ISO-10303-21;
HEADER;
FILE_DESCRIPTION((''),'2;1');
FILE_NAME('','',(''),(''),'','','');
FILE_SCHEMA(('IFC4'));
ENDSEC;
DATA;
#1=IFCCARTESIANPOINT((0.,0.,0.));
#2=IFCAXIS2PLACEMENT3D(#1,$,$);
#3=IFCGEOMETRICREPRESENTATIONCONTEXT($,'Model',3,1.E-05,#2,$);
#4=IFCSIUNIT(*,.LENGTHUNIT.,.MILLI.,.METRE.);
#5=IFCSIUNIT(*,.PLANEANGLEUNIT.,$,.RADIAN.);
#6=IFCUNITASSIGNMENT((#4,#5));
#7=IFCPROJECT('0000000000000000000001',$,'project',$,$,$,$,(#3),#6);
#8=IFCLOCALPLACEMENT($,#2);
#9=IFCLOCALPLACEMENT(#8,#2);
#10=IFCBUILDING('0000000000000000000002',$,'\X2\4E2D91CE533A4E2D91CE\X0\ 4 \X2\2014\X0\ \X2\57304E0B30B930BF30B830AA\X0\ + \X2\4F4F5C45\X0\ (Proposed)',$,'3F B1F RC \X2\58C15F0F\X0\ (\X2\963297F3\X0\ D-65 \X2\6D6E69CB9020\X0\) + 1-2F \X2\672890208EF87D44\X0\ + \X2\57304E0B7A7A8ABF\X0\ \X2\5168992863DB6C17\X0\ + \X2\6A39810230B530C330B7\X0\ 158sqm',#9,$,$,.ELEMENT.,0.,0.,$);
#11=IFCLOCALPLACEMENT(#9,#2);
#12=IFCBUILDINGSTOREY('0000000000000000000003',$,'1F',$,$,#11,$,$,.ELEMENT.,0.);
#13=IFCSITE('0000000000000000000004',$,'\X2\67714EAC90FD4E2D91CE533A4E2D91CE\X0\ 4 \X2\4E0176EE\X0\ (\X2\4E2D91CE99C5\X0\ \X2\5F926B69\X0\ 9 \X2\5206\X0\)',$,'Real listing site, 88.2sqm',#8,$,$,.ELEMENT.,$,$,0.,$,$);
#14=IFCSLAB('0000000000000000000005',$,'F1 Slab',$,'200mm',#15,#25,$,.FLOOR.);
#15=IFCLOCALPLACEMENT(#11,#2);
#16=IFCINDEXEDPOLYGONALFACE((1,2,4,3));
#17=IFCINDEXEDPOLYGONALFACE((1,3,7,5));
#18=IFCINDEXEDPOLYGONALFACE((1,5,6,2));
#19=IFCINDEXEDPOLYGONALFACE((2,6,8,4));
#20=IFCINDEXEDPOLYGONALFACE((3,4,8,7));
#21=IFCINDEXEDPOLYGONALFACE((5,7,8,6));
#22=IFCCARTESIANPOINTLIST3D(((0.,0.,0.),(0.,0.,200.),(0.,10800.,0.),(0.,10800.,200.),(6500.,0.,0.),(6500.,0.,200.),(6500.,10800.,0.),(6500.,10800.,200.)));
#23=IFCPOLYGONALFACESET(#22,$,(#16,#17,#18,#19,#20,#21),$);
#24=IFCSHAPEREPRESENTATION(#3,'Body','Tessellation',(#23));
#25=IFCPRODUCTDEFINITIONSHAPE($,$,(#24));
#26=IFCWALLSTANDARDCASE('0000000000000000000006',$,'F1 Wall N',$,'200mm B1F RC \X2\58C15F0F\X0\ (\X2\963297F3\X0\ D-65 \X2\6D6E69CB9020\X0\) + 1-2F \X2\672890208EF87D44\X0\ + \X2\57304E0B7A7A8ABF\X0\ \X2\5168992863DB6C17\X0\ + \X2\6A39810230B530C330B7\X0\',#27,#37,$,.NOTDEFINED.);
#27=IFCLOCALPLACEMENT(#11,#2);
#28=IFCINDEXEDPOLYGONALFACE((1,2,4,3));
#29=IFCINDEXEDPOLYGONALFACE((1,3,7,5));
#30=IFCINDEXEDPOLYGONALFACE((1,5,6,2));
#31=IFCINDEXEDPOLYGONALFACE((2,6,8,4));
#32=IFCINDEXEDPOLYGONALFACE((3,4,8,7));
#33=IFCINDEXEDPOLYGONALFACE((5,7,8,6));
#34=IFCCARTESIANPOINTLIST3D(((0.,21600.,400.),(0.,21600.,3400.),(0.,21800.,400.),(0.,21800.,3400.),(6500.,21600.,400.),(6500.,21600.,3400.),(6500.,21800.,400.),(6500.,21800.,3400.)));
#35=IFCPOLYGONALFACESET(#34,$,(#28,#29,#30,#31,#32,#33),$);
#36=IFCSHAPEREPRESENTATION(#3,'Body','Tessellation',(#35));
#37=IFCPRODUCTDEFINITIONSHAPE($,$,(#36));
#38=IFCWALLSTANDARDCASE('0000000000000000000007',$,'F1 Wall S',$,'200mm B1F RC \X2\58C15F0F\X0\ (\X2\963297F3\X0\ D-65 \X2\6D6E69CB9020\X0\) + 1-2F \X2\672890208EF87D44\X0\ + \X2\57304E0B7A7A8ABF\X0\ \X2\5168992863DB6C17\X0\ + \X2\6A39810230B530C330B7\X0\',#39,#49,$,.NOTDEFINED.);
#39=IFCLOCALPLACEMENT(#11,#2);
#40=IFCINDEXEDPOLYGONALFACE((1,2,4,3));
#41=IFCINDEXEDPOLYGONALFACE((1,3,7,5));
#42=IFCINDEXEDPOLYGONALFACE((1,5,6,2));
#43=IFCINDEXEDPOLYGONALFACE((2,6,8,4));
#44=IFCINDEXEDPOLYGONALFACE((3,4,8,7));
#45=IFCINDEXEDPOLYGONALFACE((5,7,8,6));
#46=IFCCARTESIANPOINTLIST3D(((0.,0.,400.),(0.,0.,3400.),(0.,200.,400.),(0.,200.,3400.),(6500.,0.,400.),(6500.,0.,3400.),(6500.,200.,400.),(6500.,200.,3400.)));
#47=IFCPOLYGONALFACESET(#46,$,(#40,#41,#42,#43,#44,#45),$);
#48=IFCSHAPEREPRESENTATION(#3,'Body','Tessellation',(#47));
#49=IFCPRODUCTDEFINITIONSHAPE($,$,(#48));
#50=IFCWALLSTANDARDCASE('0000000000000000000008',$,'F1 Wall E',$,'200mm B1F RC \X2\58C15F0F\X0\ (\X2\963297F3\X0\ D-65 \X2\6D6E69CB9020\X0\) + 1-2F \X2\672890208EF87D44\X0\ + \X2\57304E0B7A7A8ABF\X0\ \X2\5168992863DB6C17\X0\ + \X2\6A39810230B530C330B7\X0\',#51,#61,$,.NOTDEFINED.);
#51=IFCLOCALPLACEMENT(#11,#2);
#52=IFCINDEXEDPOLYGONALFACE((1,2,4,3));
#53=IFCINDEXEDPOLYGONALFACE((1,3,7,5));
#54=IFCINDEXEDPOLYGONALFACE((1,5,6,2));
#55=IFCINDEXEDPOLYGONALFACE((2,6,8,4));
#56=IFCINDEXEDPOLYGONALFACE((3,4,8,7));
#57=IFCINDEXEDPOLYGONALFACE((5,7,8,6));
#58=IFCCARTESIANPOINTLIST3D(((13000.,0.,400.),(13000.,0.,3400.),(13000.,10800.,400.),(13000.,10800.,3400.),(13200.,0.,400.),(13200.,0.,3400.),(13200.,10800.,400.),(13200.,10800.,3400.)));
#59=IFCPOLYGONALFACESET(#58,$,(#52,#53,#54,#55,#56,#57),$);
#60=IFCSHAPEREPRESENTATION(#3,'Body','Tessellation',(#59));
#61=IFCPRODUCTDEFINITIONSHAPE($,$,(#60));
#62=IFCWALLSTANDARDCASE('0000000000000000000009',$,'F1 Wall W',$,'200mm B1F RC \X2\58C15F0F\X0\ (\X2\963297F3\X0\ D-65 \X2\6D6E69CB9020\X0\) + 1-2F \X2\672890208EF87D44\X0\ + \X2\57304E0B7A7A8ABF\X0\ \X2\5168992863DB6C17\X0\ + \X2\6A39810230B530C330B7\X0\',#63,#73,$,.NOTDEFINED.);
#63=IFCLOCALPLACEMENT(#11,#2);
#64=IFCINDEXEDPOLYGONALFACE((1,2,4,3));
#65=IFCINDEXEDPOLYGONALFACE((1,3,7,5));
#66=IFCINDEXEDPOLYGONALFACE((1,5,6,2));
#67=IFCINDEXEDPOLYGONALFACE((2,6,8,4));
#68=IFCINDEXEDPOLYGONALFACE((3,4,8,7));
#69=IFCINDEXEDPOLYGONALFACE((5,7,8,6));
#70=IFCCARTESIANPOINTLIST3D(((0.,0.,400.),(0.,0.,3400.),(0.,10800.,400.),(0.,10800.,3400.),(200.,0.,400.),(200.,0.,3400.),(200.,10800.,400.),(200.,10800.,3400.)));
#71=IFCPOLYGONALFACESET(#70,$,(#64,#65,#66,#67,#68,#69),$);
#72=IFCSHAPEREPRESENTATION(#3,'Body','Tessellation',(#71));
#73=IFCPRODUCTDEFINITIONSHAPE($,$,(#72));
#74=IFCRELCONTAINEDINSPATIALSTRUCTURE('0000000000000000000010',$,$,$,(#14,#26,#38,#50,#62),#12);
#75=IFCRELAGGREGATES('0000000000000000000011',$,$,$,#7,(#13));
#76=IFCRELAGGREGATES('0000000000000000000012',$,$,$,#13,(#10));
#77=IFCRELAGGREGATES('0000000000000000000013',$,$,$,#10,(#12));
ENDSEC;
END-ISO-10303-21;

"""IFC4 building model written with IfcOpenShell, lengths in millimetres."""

from ifc_helpers import new_model, si_unit, frame, frame_2d, origin, place, context, project, spatial, rectangle, extrude, element, save


model = new_model("IFC4")

# Units and contexts
model_context = context("Model", 3, precision=1e-05, world=origin())
ifc_project = project(units=[si_unit("LENGTHUNIT", "METRE", prefix="MILLI"), si_unit("PLANEANGLEUNIT", "RADIAN")], contexts=[model_context])

# Site, building, storey
site_placement = place(None, origin())
site = spatial("IfcSite", under=ifc_project, at=site_placement, Name="東京都中野区中野 4 丁目 (中野駅 徒歩 9 分)", ObjectType="Real listing site, 88.2sqm", CompositionType="ELEMENT", RefElevation=0.0)
building_placement = place(site_placement, origin())
building = spatial("IfcBuilding", under=site, at=building_placement, Name="中野区中野 4 — 地下スタジオ + 住居 (Proposed)", ObjectType="3F B1F RC 壁式 (防音 D-65 浮構造) + 1-2F 木造軸組 + 地下空調 全館換気 + 樹脂サッシ 158sqm", CompositionType="ELEMENT", ElevationOfRefHeight=0.0, ElevationOfTerrain=0.0)
storey_placement = place(building_placement, origin())
storey = spatial("IfcBuildingStorey", under=building, at=storey_placement, Name="1F", CompositionType="ELEMENT", Elevation=0.0)

# Slab
slab_placement = place(storey_placement, origin())
element("IfcSlab", 1, at=slab_placement, inside=storey, Name="F1 Slab", ObjectType="200mm", PredefinedType="FLOOR", context=model_context, shape_type="SweptSolid", body=[
    extrude(rectangle(XDim=6500.0, YDim=10800.0, at=frame_2d((3250.0, 5400.0))), origin(), (0.0, 0.0, 1.0), 200.0),
])

# Walls
wall_1_placement = place(storey_placement, frame((0.0, 10800.0, 200.0)))
element("IfcWallStandardCase", 2, at=wall_1_placement, inside=storey, Name="F1 Wall N", ObjectType="200mm B1F RC 壁式 (防音 D-65 浮構造) + 1-2F 木造軸組 + 地下空調 全館換気 + 樹脂サッシ", PredefinedType="NOTDEFINED", context=model_context, shape_type="SweptSolid", body=[
    extrude(rectangle(XDim=6500.0, YDim=200.0, at=frame_2d((3250.0, 100.0))), frame((0.0, 10800.0, 200.0)), (0.0, 0.0, 1.0), 3000.0),
])
wall_2_placement = place(storey_placement, frame((0.0, 0.0, 200.0)))
element("IfcWallStandardCase", 3, at=wall_2_placement, inside=storey, Name="F1 Wall S", ObjectType="200mm B1F RC 壁式 (防音 D-65 浮構造) + 1-2F 木造軸組 + 地下空調 全館換気 + 樹脂サッシ", PredefinedType="NOTDEFINED", context=model_context, shape_type="SweptSolid", body=[
    extrude(rectangle(XDim=6500.0, YDim=200.0, at=frame_2d((3250.0, 100.0))), frame((0.0, 0.0, 200.0)), (0.0, 0.0, 1.0), 3000.0),
])
wall_3_placement = place(storey_placement, frame((6500.0, 0.0, 200.0)))
element("IfcWallStandardCase", 4, at=wall_3_placement, inside=storey, Name="F1 Wall E", ObjectType="200mm B1F RC 壁式 (防音 D-65 浮構造) + 1-2F 木造軸組 + 地下空調 全館換気 + 樹脂サッシ", PredefinedType="NOTDEFINED", context=model_context, shape_type="SweptSolid", body=[
    extrude(rectangle(XDim=200.0, YDim=10800.0, at=frame_2d((100.0, 5400.0))), frame((6500.0, 0.0, 200.0)), (0.0, 0.0, 1.0), 3000.0),
])
wall_4_placement = place(storey_placement, frame((0.0, 0.0, 200.0)))
element("IfcWallStandardCase", 5, at=wall_4_placement, inside=storey, Name="F1 Wall W", ObjectType="200mm B1F RC 壁式 (防音 D-65 浮構造) + 1-2F 木造軸組 + 地下空調 全館換気 + 樹脂サッシ", PredefinedType="NOTDEFINED", context=model_context, shape_type="SweptSolid", body=[
    extrude(rectangle(XDim=200.0, YDim=10800.0, at=frame_2d((100.0, 5400.0))), frame((0.0, 0.0, 200.0)), (0.0, 0.0, 1.0), 3000.0),
])

save(model, "model.ifc")
